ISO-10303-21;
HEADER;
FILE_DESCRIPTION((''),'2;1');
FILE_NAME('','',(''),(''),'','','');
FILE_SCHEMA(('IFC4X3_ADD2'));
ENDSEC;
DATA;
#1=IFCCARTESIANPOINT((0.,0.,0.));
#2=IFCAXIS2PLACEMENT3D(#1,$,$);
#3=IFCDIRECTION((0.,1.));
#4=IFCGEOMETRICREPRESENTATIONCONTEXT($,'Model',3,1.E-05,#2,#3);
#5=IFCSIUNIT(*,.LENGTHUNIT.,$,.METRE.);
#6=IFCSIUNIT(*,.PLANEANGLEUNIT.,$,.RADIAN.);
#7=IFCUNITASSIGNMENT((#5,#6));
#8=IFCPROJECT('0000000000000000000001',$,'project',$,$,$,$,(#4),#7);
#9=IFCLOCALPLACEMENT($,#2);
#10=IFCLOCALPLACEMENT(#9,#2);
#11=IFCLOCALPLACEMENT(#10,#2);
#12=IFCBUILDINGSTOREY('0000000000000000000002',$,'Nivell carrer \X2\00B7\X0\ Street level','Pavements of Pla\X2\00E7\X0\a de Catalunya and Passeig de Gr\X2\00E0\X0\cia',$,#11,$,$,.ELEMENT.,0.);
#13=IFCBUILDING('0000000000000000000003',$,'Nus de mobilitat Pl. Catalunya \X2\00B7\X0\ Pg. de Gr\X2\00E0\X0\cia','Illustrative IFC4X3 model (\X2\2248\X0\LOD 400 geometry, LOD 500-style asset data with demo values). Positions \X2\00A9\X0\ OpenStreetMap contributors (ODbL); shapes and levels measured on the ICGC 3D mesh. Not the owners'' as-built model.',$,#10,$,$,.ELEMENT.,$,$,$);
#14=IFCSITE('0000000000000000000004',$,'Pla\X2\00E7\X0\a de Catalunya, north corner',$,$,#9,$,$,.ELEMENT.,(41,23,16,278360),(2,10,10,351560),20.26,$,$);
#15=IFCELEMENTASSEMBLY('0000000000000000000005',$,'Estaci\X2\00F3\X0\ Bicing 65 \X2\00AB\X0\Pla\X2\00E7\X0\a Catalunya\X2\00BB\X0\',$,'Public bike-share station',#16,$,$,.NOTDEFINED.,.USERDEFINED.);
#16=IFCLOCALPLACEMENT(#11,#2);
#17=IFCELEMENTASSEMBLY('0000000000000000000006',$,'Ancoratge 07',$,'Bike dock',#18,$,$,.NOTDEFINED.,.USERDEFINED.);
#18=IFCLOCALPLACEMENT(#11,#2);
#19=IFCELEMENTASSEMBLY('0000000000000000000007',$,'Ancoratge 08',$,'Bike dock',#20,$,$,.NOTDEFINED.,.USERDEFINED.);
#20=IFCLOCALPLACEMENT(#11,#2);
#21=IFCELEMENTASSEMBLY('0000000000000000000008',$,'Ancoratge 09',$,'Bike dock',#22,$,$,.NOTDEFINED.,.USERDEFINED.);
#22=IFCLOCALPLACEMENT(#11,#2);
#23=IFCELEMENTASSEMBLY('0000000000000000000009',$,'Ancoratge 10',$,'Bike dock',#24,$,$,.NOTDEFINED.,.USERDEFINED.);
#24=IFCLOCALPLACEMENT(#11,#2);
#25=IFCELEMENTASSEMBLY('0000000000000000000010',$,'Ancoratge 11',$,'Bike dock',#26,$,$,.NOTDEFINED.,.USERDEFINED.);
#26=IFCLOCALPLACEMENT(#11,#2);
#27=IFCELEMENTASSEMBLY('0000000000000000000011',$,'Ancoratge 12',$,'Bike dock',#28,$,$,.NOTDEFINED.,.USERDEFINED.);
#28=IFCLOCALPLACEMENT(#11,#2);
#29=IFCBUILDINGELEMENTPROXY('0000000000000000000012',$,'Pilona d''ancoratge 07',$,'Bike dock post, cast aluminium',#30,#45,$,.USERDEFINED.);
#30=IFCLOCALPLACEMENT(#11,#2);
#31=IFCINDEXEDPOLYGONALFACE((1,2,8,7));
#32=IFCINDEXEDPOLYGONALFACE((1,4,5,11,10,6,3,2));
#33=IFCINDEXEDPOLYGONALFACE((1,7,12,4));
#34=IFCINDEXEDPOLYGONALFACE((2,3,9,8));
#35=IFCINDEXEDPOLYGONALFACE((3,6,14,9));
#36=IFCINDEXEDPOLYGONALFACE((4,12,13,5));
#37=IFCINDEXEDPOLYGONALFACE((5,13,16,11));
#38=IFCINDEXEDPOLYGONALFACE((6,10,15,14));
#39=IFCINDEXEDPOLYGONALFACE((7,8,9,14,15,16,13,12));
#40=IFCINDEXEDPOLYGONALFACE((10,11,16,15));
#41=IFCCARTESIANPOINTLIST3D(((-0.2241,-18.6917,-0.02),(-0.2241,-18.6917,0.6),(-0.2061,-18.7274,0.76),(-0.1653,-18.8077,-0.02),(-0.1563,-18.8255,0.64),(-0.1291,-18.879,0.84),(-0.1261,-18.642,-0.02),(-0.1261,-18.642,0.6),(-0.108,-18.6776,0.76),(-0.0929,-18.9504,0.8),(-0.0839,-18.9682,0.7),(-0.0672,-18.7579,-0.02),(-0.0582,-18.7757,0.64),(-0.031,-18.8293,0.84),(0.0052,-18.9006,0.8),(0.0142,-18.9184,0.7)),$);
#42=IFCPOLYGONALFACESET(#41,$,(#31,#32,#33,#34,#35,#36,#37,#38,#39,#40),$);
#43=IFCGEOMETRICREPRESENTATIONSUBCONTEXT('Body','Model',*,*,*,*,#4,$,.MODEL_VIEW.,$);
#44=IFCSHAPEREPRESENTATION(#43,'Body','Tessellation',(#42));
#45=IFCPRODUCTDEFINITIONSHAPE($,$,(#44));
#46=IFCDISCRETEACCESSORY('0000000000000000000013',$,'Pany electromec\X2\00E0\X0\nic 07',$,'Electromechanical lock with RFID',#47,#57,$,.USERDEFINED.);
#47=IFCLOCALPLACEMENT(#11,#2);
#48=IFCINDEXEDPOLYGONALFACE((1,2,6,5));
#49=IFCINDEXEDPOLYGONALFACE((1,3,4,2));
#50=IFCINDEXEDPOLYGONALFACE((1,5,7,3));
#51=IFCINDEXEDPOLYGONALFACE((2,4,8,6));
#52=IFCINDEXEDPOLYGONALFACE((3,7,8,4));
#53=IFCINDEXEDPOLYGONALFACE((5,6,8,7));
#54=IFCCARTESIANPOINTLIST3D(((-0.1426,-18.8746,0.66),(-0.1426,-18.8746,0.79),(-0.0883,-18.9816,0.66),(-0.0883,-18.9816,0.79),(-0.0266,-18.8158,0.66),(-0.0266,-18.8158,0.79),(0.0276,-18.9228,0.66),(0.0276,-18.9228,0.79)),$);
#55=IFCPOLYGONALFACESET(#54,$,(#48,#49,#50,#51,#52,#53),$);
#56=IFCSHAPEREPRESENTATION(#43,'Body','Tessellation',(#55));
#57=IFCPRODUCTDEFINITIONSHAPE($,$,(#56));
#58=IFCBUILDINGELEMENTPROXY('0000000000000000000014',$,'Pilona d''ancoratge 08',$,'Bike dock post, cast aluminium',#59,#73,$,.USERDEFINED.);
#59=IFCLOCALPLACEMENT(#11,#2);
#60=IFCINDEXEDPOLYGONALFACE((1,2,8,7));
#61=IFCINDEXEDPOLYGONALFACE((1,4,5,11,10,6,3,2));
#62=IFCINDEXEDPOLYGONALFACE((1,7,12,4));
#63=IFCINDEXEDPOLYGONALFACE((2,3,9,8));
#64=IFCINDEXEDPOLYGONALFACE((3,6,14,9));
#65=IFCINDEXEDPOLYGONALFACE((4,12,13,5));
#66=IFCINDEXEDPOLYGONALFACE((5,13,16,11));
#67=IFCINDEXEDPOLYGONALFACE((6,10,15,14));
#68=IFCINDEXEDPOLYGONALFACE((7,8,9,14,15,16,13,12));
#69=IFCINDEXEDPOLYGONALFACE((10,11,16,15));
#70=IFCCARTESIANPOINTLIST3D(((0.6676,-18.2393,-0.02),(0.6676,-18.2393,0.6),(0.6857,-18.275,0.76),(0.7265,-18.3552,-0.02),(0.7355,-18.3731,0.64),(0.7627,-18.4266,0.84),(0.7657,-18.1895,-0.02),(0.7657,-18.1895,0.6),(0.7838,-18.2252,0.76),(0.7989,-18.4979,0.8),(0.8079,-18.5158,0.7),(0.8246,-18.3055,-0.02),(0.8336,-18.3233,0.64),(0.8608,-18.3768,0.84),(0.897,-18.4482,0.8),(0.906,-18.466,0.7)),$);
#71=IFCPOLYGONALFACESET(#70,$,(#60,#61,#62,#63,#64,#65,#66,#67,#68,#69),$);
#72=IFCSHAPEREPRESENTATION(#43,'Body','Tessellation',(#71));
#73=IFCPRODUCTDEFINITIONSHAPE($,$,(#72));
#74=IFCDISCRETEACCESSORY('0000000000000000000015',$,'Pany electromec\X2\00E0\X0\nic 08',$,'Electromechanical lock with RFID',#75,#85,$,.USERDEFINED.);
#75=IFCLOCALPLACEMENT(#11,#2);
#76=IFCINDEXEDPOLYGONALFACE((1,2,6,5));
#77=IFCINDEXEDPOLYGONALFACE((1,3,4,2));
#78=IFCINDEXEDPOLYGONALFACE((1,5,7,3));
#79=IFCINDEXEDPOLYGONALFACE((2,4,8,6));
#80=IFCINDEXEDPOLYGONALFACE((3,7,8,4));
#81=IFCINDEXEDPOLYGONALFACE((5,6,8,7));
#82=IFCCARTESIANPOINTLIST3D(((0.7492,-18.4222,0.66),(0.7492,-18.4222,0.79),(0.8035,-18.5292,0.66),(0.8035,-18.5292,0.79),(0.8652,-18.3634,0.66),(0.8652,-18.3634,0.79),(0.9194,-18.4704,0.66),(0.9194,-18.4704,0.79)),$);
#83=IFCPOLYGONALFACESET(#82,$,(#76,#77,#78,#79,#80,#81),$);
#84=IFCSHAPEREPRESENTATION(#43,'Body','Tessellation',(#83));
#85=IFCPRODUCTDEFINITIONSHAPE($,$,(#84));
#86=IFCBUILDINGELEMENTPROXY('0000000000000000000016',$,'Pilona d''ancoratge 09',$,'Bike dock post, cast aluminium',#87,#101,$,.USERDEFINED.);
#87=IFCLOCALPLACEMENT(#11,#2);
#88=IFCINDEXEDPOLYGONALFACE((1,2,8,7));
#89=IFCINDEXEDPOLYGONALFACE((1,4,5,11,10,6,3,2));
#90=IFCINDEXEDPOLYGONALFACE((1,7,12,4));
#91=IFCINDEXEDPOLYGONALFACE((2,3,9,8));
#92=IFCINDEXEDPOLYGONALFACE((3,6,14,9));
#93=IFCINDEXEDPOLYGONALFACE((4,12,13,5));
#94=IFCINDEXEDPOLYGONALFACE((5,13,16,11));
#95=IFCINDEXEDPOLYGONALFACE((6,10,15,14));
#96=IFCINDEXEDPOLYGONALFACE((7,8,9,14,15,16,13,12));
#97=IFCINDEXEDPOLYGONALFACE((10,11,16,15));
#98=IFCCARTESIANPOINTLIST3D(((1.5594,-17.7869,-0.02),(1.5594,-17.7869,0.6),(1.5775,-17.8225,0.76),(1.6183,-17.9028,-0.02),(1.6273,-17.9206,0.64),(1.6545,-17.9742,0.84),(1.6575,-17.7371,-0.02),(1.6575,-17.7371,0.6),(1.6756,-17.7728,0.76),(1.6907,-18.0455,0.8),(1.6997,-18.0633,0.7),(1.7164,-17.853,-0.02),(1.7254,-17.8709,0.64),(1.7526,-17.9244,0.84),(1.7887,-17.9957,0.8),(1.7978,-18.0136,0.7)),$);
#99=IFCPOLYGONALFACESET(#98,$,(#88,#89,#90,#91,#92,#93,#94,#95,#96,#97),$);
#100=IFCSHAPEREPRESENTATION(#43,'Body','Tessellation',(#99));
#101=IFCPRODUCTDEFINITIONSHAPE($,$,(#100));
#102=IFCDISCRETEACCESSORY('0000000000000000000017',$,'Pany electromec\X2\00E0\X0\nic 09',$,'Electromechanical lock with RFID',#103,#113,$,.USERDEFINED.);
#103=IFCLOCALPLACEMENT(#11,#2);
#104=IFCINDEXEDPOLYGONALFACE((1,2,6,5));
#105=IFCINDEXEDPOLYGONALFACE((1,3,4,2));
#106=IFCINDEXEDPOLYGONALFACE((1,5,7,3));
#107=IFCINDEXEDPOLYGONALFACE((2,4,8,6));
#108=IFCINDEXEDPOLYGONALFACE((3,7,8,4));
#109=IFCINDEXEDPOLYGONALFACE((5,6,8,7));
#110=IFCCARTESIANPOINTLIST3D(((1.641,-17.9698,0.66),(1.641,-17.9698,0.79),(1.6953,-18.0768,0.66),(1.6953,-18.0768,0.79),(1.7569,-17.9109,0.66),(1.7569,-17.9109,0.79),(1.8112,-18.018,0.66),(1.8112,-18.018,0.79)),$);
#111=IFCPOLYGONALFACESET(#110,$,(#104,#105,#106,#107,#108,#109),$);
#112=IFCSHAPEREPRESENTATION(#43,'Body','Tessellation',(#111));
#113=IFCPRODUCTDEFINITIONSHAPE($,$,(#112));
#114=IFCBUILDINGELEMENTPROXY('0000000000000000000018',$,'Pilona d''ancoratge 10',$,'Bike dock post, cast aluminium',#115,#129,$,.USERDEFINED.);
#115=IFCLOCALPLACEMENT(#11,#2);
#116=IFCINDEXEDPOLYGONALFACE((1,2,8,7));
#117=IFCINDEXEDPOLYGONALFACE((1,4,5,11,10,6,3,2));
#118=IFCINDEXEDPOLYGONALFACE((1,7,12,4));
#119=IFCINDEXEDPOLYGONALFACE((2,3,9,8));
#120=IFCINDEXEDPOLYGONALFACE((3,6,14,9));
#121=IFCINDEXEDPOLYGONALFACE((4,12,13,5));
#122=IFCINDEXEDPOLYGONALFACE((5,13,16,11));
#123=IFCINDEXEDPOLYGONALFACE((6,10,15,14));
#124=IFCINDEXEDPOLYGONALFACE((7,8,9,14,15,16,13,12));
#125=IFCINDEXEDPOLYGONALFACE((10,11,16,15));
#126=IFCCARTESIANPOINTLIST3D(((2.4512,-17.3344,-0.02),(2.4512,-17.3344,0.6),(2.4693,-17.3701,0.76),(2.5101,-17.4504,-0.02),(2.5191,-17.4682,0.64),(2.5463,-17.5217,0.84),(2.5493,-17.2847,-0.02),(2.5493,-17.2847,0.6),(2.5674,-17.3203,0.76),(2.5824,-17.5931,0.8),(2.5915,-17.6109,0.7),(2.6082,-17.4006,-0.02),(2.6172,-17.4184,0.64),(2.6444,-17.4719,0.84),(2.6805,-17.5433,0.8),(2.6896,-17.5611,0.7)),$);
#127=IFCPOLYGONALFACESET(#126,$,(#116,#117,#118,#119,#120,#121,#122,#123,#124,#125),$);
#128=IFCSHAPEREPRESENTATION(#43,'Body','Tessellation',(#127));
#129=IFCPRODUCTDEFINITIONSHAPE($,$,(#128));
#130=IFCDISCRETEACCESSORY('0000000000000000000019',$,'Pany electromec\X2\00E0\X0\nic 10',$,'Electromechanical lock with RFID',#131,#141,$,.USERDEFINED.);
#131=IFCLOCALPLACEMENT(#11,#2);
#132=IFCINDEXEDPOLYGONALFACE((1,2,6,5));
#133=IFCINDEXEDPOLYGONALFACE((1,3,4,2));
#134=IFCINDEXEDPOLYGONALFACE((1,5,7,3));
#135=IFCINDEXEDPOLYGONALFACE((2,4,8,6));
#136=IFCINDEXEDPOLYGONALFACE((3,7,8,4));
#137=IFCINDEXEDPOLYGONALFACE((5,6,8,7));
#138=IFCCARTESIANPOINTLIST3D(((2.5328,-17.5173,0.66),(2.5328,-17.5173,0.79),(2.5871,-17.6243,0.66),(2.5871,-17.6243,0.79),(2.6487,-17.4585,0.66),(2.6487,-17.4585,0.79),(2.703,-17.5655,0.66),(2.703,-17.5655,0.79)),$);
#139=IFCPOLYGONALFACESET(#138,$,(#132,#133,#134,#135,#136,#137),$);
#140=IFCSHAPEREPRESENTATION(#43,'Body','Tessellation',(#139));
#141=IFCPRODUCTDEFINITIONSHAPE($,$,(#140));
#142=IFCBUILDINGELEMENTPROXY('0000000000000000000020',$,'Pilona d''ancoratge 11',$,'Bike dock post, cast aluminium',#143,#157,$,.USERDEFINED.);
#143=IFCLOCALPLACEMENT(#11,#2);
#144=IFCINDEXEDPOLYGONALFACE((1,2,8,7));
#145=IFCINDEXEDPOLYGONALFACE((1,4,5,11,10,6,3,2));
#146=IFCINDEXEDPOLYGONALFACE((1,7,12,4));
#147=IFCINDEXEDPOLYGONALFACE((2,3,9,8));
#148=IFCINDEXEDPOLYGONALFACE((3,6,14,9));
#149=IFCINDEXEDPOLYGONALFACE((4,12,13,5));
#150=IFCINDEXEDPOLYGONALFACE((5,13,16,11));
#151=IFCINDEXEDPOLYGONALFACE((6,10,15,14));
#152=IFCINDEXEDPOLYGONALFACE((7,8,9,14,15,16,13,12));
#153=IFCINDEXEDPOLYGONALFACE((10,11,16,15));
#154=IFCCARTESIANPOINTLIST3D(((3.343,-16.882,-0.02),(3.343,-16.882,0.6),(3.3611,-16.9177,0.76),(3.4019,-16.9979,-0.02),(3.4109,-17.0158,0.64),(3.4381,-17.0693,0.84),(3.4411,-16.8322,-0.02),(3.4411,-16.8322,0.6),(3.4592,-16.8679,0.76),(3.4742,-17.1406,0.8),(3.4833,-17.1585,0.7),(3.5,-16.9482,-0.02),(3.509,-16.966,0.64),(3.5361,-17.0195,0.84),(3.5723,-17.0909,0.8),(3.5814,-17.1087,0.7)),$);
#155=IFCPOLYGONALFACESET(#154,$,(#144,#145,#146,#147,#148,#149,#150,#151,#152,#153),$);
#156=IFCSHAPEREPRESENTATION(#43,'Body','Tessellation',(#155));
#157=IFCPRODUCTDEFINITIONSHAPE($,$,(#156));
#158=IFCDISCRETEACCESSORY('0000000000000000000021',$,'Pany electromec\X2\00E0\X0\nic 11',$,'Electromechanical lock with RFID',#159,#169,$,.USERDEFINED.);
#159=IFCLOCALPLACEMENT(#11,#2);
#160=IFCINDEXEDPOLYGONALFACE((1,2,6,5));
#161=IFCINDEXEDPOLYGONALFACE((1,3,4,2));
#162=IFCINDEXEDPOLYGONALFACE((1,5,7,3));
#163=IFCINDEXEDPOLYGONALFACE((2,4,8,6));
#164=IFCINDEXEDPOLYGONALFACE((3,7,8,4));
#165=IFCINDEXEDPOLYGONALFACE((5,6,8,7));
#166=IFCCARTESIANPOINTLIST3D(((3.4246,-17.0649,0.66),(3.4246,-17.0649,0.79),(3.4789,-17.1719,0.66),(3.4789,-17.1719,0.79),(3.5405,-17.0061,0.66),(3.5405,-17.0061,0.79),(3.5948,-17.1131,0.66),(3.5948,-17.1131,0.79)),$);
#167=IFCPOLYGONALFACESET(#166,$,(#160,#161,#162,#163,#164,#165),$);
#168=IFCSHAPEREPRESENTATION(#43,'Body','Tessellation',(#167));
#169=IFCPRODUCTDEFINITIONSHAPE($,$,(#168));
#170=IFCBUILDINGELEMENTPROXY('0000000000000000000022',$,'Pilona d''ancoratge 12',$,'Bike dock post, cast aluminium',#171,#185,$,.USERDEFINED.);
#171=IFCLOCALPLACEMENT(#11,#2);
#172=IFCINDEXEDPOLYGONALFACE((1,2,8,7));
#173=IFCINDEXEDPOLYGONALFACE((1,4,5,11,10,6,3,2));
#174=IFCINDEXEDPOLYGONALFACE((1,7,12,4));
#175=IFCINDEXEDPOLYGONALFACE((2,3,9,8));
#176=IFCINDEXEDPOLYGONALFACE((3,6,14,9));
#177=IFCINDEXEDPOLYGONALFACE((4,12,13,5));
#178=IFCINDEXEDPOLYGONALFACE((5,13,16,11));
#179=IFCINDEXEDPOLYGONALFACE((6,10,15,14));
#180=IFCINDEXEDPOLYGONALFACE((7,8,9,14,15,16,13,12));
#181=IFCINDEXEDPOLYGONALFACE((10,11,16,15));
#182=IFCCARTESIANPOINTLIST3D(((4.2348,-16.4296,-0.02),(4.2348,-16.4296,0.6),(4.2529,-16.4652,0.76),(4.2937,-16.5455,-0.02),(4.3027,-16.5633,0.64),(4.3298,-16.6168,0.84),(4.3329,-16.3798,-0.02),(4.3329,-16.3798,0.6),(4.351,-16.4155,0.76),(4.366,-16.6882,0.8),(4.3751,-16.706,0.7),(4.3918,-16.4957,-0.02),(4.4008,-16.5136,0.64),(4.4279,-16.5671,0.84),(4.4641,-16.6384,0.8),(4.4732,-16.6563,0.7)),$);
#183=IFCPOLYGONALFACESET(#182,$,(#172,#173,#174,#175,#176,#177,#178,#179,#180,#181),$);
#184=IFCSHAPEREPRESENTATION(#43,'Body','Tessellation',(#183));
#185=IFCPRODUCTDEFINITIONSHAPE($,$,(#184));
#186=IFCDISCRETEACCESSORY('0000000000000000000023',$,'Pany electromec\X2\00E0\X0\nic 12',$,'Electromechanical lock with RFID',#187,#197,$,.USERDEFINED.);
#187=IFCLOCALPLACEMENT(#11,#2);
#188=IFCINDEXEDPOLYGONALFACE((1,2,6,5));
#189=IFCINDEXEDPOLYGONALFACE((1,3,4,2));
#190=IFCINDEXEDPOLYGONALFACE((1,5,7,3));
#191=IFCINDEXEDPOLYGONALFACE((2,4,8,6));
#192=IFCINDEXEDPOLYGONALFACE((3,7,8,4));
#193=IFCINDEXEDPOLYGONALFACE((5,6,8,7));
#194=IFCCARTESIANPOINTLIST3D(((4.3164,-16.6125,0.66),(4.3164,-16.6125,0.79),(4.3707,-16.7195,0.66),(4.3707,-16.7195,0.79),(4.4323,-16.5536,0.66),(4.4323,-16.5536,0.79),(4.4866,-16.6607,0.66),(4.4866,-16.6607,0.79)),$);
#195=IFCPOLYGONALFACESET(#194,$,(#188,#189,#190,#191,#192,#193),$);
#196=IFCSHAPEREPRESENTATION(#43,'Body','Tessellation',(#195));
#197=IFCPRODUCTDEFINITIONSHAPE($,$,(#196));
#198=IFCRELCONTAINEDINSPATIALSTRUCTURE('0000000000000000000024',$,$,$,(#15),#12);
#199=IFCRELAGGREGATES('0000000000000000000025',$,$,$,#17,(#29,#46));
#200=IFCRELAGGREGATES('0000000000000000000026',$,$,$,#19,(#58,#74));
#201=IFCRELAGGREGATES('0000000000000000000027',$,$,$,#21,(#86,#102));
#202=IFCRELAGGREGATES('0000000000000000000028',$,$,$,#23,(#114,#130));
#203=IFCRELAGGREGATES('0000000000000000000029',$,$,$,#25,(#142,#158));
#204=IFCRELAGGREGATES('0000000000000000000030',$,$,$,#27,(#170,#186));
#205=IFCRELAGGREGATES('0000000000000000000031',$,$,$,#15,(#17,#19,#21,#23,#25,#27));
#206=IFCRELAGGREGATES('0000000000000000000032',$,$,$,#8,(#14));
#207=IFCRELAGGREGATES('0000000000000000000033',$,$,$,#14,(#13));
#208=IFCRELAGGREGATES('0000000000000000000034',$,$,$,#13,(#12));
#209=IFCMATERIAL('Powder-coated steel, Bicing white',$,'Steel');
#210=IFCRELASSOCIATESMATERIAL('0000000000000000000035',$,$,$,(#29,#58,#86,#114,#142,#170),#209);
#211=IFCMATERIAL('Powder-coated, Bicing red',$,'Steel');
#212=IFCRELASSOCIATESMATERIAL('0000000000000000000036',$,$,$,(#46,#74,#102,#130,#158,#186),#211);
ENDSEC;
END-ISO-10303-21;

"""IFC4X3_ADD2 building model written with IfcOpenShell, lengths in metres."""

from ifc_helpers import new_model, si_unit, direction, frame, frame_2d, origin, place, context, subcontext, project, spatial, polyline, rectangle, outline, extrude, material, element, aggregate, save


model = new_model("IFC4X3_ADD2")

# Units and contexts
model_context = context("Model", 3, precision=1e-05, world=origin(), true_north=direction((0.0, 1.0)))
body_context = subcontext(model_context, "Body", "Model", "MODEL_VIEW")
ifc_project = project(units=[si_unit("LENGTHUNIT", "METRE"), si_unit("PLANEANGLEUNIT", "RADIAN")], contexts=[model_context])

# Site, building, storey
site_placement = place(None, origin())
site = spatial("IfcSite", under=ifc_project, at=site_placement, Name="Plaça de Catalunya, north corner", CompositionType="ELEMENT", RefLatitude=(41, 23, 16, 278360), RefLongitude=(2, 10, 10, 351560), RefElevation=20.26)
building_placement = place(site_placement, origin())
building = spatial("IfcBuilding", under=site, at=building_placement, Name="Nus de mobilitat Pl. Catalunya · Pg. de Gràcia", Description="Illustrative IFC4X3 model (≈LOD 400 geometry, LOD 500-style asset data with demo values). Positions © OpenStreetMap contributors (ODbL); shapes and levels measured on the ICGC 3D mesh. Not the owners' as-built model.", CompositionType="ELEMENT")
storey_placement = place(building_placement, origin())
storey = spatial("IfcBuildingStorey", under=building, at=storey_placement, Name="Nivell carrer · Street level", Description="Pavements of Plaça de Catalunya and Passeig de Gràcia", CompositionType="ELEMENT", Elevation=0.0)

# Element assemblies, building element proxies, discrete accessories
assembly_1_placement = place(building_placement, origin())
assembly_1 = element("IfcElementAssembly", 1, at=assembly_1_placement, inside=storey, Name="Estació Bicing 65 «Plaça Catalunya»", ObjectType="Public bike-share station", AssemblyPlace="NOTDEFINED", PredefinedType="USERDEFINED")
assembly_2_placement = place(building_placement, origin())
assembly_2 = element("IfcElementAssembly", 2, at=assembly_2_placement, Name="Ancoratge 07", ObjectType="Bike dock", AssemblyPlace="NOTDEFINED", PredefinedType="USERDEFINED")
assembly_3_placement = place(building_placement, origin())
assembly_3 = element("IfcElementAssembly", 3, at=assembly_3_placement, Name="Ancoratge 08", ObjectType="Bike dock", AssemblyPlace="NOTDEFINED", PredefinedType="USERDEFINED")
assembly_4_placement = place(building_placement, origin())
assembly_4 = element("IfcElementAssembly", 4, at=assembly_4_placement, Name="Ancoratge 09", ObjectType="Bike dock", AssemblyPlace="NOTDEFINED", PredefinedType="USERDEFINED")
assembly_5_placement = place(building_placement, origin())
assembly_5 = element("IfcElementAssembly", 5, at=assembly_5_placement, Name="Ancoratge 10", ObjectType="Bike dock", AssemblyPlace="NOTDEFINED", PredefinedType="USERDEFINED")
assembly_6_placement = place(building_placement, origin())
assembly_6 = element("IfcElementAssembly", 6, at=assembly_6_placement, Name="Ancoratge 11", ObjectType="Bike dock", AssemblyPlace="NOTDEFINED", PredefinedType="USERDEFINED")
assembly_7_placement = place(building_placement, origin())
assembly_7 = element("IfcElementAssembly", 7, at=assembly_7_placement, Name="Ancoratge 12", ObjectType="Bike dock", AssemblyPlace="NOTDEFINED", PredefinedType="USERDEFINED")
ifc_material_1 = material(Name="Powder-coated, Bicing red", Category="Steel")
ifc_material_2 = material(Name="Powder-coated steel, Bicing white", Category="Steel")
proxy_1_placement = place(building_placement, origin())
proxy_1 = element("IfcBuildingElementProxy", 8, at=proxy_1_placement, material=ifc_material_2, Name="Pilona d'ancoratge 07", ObjectType="Bike dock post, cast aluminium", PredefinedType="USERDEFINED", context=body_context, shape_type="SweptSolid", body=[
    extrude(outline(polyline([(0.07, 0.06), (0.07, 0.68), (0.03, 0.84), (-0.14, 0.92), (-0.22, 0.88), (-0.24, 0.78), (-0.08, 0.72), (-0.06, 0.06), (0.07, 0.06)])), frame((-0.1925, -18.7542, -0.08), z_axis=(0.891798, 0.452435, 0.0), x_axis=(-0.452435, 0.891798, 0.0)), (0.0, 0.0, 1.0), 0.11),
])
discrete_accessory_1_placement = place(building_placement, origin())
discrete_accessory_1 = element("IfcDiscreteAccessory", 9, at=discrete_accessory_1_placement, material=ifc_material_1, Name="Pany electromecànic 07", ObjectType="Electromechanical lock with RFID", PredefinedType="USERDEFINED", context=body_context, shape_type="SweptSolid", body=[
    extrude(rectangle(XDim=0.13, YDim=0.12, at=frame_2d((0.0, 0.0), x_axis=(0.891798, 0.452435))), frame((-0.0575, -18.8987, 0.66)), (0.0, 0.0, 1.0), 0.13),
])
aggregate(assembly_2, [proxy_1, discrete_accessory_1])
proxy_2_placement = place(building_placement, origin())
proxy_2 = element("IfcBuildingElementProxy", 10, at=proxy_2_placement, material=ifc_material_2, Name="Pilona d'ancoratge 08", ObjectType="Bike dock post, cast aluminium", PredefinedType="USERDEFINED", context=body_context, shape_type="SweptSolid", body=[
    extrude(outline(polyline([(0.07, 0.06), (0.07, 0.68), (0.03, 0.84), (-0.14, 0.92), (-0.22, 0.88), (-0.24, 0.78), (-0.08, 0.72), (-0.06, 0.06), (0.07, 0.06)])), frame((0.6993, -18.3017, -0.08), z_axis=(0.891798, 0.452435, 0.0), x_axis=(-0.452435, 0.891798, 0.0)), (0.0, 0.0, 1.0), 0.11),
])
discrete_accessory_2_placement = place(building_placement, origin())
discrete_accessory_2 = element("IfcDiscreteAccessory", 11, at=discrete_accessory_2_placement, material=ifc_material_1, Name="Pany electromecànic 08", ObjectType="Electromechanical lock with RFID", PredefinedType="USERDEFINED", context=body_context, shape_type="SweptSolid", body=[
    extrude(rectangle(XDim=0.13, YDim=0.12, at=frame_2d((0.0, 0.0), x_axis=(0.891798, 0.452435))), frame((0.8343, -18.4463, 0.66)), (0.0, 0.0, 1.0), 0.13),
])
aggregate(assembly_3, [proxy_2, discrete_accessory_2])
proxy_3_placement = place(building_placement, origin())
proxy_3 = element("IfcBuildingElementProxy", 12, at=proxy_3_placement, material=ifc_material_2, Name="Pilona d'ancoratge 09", ObjectType="Bike dock post, cast aluminium", PredefinedType="USERDEFINED", context=body_context, shape_type="SweptSolid", body=[
    extrude(outline(polyline([(0.07, 0.06), (0.07, 0.68), (0.03, 0.84), (-0.14, 0.92), (-0.22, 0.88), (-0.24, 0.78), (-0.08, 0.72), (-0.06, 0.06), (0.07, 0.06)])), frame((1.5911, -17.8493, -0.08), z_axis=(0.891798, 0.452435, 0.0), x_axis=(-0.452435, 0.891798, 0.0)), (0.0, 0.0, 1.0), 0.11),
])
discrete_accessory_3_placement = place(building_placement, origin())
discrete_accessory_3 = element("IfcDiscreteAccessory", 13, at=discrete_accessory_3_placement, material=ifc_material_1, Name="Pany electromecànic 09", ObjectType="Electromechanical lock with RFID", PredefinedType="USERDEFINED", context=body_context, shape_type="SweptSolid", body=[
    extrude(rectangle(XDim=0.13, YDim=0.12, at=frame_2d((0.0, 0.0), x_axis=(0.891798, 0.452435))), frame((1.7261, -17.9939, 0.66)), (0.0, 0.0, 1.0), 0.13),
])
aggregate(assembly_4, [proxy_3, discrete_accessory_3])
proxy_4_placement = place(building_placement, origin())
proxy_4 = element("IfcBuildingElementProxy", 14, at=proxy_4_placement, material=ifc_material_2, Name="Pilona d'ancoratge 10", ObjectType="Bike dock post, cast aluminium", PredefinedType="USERDEFINED", context=body_context, shape_type="SweptSolid", body=[
    extrude(outline(polyline([(0.07, 0.06), (0.07, 0.68), (0.03, 0.84), (-0.14, 0.92), (-0.22, 0.88), (-0.24, 0.78), (-0.08, 0.72), (-0.06, 0.06), (0.07, 0.06)])), frame((2.4829, -17.3969, -0.08), z_axis=(0.891798, 0.452435, 0.0), x_axis=(-0.452435, 0.891798, 0.0)), (0.0, 0.0, 1.0), 0.11),
])
discrete_accessory_4_placement = place(building_placement, origin())
discrete_accessory_4 = element("IfcDiscreteAccessory", 15, at=discrete_accessory_4_placement, material=ifc_material_1, Name="Pany electromecànic 10", ObjectType="Electromechanical lock with RFID", PredefinedType="USERDEFINED", context=body_context, shape_type="SweptSolid", body=[
    extrude(rectangle(XDim=0.13, YDim=0.12, at=frame_2d((0.0, 0.0), x_axis=(0.891798, 0.452435))), frame((2.6179, -17.5414, 0.66)), (0.0, 0.0, 1.0), 0.13),
])
aggregate(assembly_5, [proxy_4, discrete_accessory_4])
proxy_5_placement = place(building_placement, origin())
proxy_5 = element("IfcBuildingElementProxy", 16, at=proxy_5_placement, material=ifc_material_2, Name="Pilona d'ancoratge 11", ObjectType="Bike dock post, cast aluminium", PredefinedType="USERDEFINED", context=body_context, shape_type="SweptSolid", body=[
    extrude(outline(polyline([(0.07, 0.06), (0.07, 0.68), (0.03, 0.84), (-0.14, 0.92), (-0.22, 0.88), (-0.24, 0.78), (-0.08, 0.72), (-0.06, 0.06), (0.07, 0.06)])), frame((3.3747, -16.9444, -0.08), z_axis=(0.891798, 0.452435, 0.0), x_axis=(-0.452435, 0.891798, 0.0)), (0.0, 0.0, 1.0), 0.11),
])
discrete_accessory_5_placement = place(building_placement, origin())
discrete_accessory_5 = element("IfcDiscreteAccessory", 17, at=discrete_accessory_5_placement, material=ifc_material_1, Name="Pany electromecànic 11", ObjectType="Electromechanical lock with RFID", PredefinedType="USERDEFINED", context=body_context, shape_type="SweptSolid", body=[
    extrude(rectangle(XDim=0.13, YDim=0.12, at=frame_2d((0.0, 0.0), x_axis=(0.891798, 0.452435))), frame((3.5097, -17.089, 0.66)), (0.0, 0.0, 1.0), 0.13),
])
aggregate(assembly_6, [proxy_5, discrete_accessory_5])
proxy_6_placement = place(building_placement, origin())
proxy_6 = element("IfcBuildingElementProxy", 18, at=proxy_6_placement, material=ifc_material_2, Name="Pilona d'ancoratge 12", ObjectType="Bike dock post, cast aluminium", PredefinedType="USERDEFINED", context=body_context, shape_type="SweptSolid", body=[
    extrude(outline(polyline([(0.07, 0.06), (0.07, 0.68), (0.03, 0.84), (-0.14, 0.92), (-0.22, 0.88), (-0.24, 0.78), (-0.08, 0.72), (-0.06, 0.06), (0.07, 0.06)])), frame((4.2665, -16.492, -0.08), z_axis=(0.891798, 0.452435, 0.0), x_axis=(-0.452435, 0.891798, 0.0)), (0.0, 0.0, 1.0), 0.11),
])
discrete_accessory_6_placement = place(building_placement, origin())
discrete_accessory_6 = element("IfcDiscreteAccessory", 19, at=discrete_accessory_6_placement, material=ifc_material_1, Name="Pany electromecànic 12", ObjectType="Electromechanical lock with RFID", PredefinedType="USERDEFINED", context=body_context, shape_type="SweptSolid", body=[
    extrude(rectangle(XDim=0.13, YDim=0.12, at=frame_2d((0.0, 0.0), x_axis=(0.891798, 0.452435))), frame((4.4015, -16.6366, 0.66)), (0.0, 0.0, 1.0), 0.13),
])
aggregate(assembly_7, [proxy_6, discrete_accessory_6])
aggregate(assembly_1, [assembly_2, assembly_3, assembly_4, assembly_5, assembly_6, assembly_7])

save(model, "model.ifc")
